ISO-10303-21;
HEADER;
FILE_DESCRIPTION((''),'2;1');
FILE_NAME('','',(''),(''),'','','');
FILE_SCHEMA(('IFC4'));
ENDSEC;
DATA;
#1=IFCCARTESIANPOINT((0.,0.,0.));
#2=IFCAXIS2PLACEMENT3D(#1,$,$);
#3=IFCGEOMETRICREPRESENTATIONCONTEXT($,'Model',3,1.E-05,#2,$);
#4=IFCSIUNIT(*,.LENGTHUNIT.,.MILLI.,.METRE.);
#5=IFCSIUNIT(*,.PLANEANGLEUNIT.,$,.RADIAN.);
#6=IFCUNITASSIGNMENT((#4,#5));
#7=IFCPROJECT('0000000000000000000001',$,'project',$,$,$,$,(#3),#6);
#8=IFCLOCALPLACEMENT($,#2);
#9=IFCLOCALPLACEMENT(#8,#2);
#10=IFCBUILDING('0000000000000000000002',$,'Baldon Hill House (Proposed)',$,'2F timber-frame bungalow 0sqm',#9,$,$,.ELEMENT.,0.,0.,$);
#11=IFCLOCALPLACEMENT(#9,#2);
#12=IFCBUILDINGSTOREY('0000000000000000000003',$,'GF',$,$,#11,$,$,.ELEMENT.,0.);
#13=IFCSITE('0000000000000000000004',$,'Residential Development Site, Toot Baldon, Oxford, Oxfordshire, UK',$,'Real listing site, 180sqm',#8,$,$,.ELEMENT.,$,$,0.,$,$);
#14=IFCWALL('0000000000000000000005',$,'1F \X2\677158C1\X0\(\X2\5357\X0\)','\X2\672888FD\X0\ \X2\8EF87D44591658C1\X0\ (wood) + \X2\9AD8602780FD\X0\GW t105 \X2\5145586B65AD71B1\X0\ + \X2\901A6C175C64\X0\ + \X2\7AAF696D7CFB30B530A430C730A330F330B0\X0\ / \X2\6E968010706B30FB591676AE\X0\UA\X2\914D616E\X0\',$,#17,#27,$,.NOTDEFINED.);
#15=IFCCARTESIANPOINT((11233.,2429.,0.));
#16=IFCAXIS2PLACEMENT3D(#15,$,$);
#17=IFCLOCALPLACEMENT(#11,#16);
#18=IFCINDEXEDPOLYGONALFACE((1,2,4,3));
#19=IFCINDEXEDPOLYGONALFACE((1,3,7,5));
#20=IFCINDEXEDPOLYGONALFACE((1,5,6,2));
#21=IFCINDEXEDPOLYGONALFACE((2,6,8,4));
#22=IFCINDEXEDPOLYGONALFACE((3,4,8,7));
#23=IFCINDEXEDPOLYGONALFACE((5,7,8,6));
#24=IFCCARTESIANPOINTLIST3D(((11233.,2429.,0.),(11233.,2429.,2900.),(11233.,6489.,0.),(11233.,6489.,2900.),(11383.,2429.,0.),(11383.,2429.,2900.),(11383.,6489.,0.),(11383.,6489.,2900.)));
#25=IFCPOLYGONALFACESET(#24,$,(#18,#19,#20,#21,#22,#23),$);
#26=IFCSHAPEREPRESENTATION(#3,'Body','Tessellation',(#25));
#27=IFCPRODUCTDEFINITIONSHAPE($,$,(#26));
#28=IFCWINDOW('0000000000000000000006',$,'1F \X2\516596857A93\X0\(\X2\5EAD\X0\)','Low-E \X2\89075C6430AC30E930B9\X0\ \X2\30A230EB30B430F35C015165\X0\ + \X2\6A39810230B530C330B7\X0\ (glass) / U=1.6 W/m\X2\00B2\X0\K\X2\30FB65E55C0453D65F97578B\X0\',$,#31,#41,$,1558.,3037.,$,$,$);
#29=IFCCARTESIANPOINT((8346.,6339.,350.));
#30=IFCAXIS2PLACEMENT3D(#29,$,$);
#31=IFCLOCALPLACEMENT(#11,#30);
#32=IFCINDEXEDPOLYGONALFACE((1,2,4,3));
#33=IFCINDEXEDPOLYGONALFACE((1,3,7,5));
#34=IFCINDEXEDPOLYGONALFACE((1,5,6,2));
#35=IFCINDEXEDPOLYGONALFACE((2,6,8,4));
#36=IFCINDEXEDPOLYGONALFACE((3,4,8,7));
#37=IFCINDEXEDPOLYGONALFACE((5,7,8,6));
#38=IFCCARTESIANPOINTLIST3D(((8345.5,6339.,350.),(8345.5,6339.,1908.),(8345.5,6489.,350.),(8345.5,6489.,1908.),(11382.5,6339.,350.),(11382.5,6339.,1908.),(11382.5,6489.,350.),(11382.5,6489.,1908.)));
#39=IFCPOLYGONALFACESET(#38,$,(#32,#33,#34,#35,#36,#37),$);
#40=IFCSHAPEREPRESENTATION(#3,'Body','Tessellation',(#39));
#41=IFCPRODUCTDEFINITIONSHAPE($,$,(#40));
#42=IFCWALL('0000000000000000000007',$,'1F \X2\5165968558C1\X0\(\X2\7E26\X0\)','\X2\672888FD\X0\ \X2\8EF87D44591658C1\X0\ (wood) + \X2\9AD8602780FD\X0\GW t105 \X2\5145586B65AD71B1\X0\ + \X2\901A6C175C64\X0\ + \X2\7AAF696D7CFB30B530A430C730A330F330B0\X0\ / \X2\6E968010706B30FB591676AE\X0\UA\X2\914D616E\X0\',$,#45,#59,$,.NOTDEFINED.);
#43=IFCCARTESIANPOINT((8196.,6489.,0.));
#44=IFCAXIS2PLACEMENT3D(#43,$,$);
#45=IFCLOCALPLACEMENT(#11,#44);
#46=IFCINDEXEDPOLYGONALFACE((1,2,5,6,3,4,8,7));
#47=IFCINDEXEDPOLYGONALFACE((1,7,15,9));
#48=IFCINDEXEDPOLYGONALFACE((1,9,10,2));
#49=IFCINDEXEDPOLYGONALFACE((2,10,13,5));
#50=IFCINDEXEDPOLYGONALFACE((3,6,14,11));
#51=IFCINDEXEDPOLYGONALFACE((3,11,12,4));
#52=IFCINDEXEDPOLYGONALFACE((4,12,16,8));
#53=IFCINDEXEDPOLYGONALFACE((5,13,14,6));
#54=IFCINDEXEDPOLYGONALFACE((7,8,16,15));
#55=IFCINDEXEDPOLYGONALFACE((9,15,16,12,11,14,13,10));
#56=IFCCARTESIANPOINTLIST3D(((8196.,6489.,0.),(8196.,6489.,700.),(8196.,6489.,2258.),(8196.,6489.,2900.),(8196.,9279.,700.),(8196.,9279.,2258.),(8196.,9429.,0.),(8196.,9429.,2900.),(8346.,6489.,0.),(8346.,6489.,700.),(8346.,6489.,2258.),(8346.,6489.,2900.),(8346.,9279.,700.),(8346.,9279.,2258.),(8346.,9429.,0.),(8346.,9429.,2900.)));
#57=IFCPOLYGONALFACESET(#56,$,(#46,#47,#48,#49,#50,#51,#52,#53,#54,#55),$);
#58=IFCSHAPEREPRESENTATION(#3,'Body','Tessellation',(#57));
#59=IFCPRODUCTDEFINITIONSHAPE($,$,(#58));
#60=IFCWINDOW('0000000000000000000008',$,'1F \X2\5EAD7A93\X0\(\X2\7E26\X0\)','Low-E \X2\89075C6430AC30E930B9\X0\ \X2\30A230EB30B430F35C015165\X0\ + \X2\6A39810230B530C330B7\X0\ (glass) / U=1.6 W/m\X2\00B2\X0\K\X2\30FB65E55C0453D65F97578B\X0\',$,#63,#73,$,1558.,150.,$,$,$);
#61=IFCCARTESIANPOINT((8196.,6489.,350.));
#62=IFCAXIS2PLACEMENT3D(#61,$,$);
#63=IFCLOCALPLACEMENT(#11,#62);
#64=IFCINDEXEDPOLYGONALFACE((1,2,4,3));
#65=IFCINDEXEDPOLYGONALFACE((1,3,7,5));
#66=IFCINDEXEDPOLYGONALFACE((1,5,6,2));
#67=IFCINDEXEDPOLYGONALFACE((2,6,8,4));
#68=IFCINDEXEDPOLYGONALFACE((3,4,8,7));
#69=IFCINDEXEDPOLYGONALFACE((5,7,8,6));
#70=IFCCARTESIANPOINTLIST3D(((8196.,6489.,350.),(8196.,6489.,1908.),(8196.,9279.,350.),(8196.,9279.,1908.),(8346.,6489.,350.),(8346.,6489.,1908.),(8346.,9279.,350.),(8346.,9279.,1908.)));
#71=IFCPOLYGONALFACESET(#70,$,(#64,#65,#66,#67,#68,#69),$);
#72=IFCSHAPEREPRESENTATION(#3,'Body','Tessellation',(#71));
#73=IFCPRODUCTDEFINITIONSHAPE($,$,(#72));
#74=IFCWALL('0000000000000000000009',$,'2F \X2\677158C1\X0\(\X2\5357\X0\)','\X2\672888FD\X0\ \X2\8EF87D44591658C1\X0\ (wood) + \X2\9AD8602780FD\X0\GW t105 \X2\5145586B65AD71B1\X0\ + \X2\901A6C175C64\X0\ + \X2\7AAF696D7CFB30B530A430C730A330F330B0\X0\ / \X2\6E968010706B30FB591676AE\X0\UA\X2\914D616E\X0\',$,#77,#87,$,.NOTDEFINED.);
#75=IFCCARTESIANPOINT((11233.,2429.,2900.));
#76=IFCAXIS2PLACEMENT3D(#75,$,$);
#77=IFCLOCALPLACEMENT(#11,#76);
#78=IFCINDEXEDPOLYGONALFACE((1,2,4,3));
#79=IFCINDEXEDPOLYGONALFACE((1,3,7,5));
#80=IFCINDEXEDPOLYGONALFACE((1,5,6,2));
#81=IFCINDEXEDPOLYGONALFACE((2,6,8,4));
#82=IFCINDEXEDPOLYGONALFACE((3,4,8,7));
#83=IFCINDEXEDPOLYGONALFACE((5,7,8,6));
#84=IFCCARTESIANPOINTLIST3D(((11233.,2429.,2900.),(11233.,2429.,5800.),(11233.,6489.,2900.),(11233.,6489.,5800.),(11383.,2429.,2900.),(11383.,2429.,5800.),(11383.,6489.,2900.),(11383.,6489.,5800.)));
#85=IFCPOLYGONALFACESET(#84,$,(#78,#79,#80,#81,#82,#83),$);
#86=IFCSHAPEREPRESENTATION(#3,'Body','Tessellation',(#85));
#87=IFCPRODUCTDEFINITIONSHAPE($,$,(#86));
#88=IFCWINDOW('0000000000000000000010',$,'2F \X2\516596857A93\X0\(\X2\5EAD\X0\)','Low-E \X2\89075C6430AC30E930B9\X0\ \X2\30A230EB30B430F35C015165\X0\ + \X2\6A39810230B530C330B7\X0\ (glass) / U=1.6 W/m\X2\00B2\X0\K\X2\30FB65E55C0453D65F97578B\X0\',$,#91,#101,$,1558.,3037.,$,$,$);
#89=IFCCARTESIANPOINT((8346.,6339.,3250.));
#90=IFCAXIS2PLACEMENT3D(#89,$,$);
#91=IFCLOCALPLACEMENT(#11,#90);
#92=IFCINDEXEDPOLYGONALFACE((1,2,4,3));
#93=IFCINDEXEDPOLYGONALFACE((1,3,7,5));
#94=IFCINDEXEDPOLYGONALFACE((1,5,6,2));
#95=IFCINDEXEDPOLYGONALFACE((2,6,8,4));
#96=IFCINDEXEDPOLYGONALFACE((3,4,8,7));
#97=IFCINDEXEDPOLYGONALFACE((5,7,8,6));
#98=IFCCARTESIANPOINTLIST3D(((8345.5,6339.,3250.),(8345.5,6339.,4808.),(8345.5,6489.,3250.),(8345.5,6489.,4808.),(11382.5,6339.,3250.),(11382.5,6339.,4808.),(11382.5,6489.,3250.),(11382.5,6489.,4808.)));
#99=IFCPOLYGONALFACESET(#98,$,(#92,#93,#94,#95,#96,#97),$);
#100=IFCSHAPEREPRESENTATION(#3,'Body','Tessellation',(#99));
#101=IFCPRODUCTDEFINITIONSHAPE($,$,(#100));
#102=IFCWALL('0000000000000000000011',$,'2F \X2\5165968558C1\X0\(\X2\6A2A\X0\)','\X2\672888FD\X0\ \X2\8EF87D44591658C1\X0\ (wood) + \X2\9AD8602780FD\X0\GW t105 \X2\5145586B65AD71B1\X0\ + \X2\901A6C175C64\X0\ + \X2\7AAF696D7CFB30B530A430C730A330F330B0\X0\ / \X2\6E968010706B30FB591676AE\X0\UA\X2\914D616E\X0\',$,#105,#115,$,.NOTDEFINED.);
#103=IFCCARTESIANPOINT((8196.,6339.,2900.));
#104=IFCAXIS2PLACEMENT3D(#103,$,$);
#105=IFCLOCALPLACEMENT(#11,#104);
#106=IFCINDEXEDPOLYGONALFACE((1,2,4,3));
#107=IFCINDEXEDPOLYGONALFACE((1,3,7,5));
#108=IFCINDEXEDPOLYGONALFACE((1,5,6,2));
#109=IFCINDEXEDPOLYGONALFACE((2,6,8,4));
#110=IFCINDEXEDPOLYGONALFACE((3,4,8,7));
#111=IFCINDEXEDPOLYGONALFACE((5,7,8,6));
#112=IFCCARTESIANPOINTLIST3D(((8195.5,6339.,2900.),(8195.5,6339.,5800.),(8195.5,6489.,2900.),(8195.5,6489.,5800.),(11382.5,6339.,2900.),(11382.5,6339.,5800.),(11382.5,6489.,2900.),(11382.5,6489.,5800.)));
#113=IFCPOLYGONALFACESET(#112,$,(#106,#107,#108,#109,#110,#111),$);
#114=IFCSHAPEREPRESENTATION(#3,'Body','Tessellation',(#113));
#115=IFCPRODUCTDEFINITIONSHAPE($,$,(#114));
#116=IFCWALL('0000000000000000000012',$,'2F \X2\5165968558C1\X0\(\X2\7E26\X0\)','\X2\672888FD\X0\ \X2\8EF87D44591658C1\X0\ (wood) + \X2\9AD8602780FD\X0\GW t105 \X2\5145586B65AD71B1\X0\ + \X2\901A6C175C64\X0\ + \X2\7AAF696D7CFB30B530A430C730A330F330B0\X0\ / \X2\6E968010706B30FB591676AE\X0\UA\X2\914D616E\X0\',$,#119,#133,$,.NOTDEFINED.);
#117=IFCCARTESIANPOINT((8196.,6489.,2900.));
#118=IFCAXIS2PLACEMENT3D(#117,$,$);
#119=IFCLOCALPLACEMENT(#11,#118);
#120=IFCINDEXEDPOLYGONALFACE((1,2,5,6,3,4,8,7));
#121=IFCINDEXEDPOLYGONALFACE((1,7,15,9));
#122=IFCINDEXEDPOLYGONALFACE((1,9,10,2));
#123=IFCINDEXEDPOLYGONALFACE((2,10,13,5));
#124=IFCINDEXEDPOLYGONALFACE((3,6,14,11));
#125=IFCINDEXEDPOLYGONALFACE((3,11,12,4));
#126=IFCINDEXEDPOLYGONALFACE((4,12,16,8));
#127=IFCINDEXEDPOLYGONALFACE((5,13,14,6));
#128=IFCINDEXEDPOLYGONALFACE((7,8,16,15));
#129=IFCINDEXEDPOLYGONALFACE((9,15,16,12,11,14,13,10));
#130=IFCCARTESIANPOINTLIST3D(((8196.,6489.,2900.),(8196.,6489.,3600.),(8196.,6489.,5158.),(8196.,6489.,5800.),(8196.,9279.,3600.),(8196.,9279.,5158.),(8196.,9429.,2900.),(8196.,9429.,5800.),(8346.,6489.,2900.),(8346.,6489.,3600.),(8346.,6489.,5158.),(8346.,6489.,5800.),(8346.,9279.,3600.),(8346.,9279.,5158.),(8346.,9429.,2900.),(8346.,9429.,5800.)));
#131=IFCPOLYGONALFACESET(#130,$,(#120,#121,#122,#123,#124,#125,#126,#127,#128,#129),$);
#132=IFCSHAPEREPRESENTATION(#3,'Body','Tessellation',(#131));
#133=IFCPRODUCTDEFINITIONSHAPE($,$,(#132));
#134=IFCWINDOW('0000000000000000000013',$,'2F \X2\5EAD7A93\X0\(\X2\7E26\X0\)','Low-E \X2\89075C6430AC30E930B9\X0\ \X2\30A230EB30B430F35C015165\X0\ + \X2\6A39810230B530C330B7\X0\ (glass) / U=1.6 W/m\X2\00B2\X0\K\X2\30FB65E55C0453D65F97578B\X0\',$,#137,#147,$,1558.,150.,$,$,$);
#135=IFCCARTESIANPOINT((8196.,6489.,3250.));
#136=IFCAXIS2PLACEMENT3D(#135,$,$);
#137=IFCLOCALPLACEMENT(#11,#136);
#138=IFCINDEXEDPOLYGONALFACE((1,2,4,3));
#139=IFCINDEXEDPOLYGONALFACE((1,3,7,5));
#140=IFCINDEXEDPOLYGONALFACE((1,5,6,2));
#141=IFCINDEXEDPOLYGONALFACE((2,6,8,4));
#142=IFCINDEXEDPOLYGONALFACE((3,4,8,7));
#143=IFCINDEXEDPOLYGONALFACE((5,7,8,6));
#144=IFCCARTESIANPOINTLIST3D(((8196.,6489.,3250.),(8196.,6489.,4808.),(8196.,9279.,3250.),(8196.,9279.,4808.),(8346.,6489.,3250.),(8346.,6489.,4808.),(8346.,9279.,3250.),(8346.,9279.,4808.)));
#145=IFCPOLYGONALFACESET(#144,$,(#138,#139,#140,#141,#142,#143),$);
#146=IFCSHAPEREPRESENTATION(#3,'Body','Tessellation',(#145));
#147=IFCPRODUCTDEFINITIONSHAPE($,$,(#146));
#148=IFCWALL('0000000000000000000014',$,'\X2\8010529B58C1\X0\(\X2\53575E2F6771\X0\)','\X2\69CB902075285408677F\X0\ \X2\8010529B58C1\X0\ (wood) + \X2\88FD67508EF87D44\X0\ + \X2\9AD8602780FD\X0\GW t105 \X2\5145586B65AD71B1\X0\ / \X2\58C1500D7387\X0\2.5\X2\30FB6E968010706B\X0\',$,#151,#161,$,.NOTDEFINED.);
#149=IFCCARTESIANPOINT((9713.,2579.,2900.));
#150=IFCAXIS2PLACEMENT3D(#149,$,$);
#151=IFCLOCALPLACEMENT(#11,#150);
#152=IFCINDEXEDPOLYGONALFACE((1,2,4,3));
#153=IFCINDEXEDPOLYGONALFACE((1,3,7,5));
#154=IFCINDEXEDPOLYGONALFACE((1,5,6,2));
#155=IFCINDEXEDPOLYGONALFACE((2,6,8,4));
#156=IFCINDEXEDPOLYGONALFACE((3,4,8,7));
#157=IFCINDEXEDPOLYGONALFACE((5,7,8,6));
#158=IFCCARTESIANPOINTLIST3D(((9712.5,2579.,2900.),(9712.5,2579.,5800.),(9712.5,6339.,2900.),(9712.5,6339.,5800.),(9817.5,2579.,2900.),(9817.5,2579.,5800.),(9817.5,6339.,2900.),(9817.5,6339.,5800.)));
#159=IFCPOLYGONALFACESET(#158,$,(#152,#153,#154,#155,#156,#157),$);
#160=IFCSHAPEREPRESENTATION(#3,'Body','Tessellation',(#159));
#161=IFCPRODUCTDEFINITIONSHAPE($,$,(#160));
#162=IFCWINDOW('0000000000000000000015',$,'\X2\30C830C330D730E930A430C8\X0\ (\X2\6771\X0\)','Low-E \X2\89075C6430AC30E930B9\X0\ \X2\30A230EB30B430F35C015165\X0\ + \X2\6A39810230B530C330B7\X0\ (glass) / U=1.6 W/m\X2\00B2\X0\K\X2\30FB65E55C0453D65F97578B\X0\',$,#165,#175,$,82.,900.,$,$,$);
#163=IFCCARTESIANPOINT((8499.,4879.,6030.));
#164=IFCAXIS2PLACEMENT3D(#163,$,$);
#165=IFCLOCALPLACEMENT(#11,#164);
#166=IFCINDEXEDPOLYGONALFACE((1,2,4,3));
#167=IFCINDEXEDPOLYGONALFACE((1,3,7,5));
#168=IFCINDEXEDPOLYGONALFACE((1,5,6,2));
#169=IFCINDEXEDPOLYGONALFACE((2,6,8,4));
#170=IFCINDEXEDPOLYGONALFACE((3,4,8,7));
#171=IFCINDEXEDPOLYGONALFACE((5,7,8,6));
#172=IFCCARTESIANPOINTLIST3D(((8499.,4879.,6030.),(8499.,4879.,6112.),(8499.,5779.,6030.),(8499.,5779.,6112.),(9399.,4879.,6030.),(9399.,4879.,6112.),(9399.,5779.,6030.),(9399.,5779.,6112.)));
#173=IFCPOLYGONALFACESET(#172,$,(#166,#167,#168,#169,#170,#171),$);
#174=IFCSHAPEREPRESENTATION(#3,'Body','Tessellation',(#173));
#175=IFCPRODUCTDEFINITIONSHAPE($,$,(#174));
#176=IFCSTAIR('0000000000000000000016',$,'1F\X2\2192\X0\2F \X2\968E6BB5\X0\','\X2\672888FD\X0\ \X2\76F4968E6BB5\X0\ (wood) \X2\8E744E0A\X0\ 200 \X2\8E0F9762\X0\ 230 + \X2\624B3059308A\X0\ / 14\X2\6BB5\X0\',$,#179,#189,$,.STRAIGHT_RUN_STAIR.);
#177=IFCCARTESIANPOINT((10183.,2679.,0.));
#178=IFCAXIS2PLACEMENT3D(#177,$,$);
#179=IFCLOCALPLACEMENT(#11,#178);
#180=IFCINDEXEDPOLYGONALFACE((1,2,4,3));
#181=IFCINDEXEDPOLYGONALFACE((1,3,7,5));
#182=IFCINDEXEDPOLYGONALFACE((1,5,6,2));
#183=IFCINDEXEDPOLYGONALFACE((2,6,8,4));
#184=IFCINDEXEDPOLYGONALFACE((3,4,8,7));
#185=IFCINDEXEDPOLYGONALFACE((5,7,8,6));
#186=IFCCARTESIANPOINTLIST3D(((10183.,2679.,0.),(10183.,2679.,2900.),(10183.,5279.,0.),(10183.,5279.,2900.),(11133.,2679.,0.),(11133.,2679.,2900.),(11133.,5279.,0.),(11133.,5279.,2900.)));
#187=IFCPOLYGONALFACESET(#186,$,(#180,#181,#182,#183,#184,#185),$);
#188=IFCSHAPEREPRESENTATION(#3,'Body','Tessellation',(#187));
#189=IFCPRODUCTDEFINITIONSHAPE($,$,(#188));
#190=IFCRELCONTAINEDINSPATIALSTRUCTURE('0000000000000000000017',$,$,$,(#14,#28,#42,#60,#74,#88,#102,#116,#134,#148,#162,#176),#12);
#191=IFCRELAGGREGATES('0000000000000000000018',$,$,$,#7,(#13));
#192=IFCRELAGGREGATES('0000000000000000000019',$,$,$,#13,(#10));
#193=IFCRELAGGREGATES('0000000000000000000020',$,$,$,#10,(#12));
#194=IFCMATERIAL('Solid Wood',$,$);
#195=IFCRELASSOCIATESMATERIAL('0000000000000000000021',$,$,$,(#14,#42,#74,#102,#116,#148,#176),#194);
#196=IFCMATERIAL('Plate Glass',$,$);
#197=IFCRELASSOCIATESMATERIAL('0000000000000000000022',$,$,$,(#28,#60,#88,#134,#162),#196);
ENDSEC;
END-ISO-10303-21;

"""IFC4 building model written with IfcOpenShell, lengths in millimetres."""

from ifc_helpers import new_model, si_unit, frame, frame_2d, origin, place, context, project, spatial, rectangle, extrude, material, element, fill, save


model = new_model("IFC4")

# Units and contexts
model_context = context("Model", 3, precision=1e-05, world=origin())
ifc_project = project(units=[si_unit("LENGTHUNIT", "METRE", prefix="MILLI"), si_unit("PLANEANGLEUNIT", "RADIAN")], contexts=[model_context])

# Site, building, storey
site_placement = place(None, origin())
site = spatial("IfcSite", under=ifc_project, at=site_placement, Name="Residential Development Site, Toot Baldon, Oxford, Oxfordshire, UK", ObjectType="Real listing site, 180sqm", CompositionType="ELEMENT", RefElevation=0.0)
building_placement = place(site_placement, origin())
building = spatial("IfcBuilding", under=site, at=building_placement, Name="Baldon Hill House (Proposed)", ObjectType="2F timber-frame bungalow 0sqm", CompositionType="ELEMENT", ElevationOfRefHeight=0.0, ElevationOfTerrain=0.0)
storey_placement = place(building_placement, origin())
storey = spatial("IfcBuildingStorey", under=building, at=storey_placement, Name="GF", CompositionType="ELEMENT", Elevation=0.0)

# Shared definitions
ifc_material_1 = material(Name="Solid Wood")

# Wall, opening, window
wall_1_placement = place(storey_placement, frame((11233.0, 2429.0, 0.0)))
wall_1 = element("IfcWall", 1, at=wall_1_placement, inside=storey, material=ifc_material_1, Name="1F 東壁(南)", Description="木製 軸組外壁 (wood) + 高性能GW t105 充填断熱 + 通気層 + 窯業系サイディング / 準耐火・外皮UA配慮", PredefinedType="NOTDEFINED", context=model_context, shape_type="SweptSolid", body=[
    extrude(rectangle(XDim=150.0, YDim=4060.0, at=frame_2d((75.0, 2030.0))), frame((11233.0, 2429.0, 0.0)), (0.0, 0.0, 1.0), 2900.0),
])
opening_1_placement = place(storey_placement, frame((8346.0, 6339.0, 350.0)))
opening_1 = element("IfcOpeningElement", 2, at=opening_1_placement, cuts=wall_1, PredefinedType="NOTDEFINED", context=model_context, shape_type="SweptSolid", body=[
    extrude(rectangle(XDim=3037.0, YDim=150.0, at=frame_2d((1518.0, 75.0))), frame((8346.0, 6339.0, 350.0)), (0.0, 0.0, 1.0), 1558.0),
])
ifc_material_2 = material(Name="Plate Glass")
window_1_placement = place(storey_placement, frame((8346.0, 6339.0, 350.0)))
window_1 = element("IfcWindow", 3, at=window_1_placement, inside=storey, material=ifc_material_2, Name="1F 入隅窓(庭)", Description="Low-E 複層ガラス アルゴン封入 + 樹脂サッシ (glass) / U=1.6 W/m²K・日射取得型", OverallHeight=1558.0, OverallWidth=3037.0, context=model_context, shape_type="SweptSolid", body=[
    extrude(rectangle(XDim=3037.0, YDim=150.0, at=frame_2d((1518.0, 75.0))), frame((8346.0, 6339.0, 350.0)), (0.0, 0.0, 1.0), 1558.0),
])
fill(opening_1, window_1)

# Wall, opening, window
wall_2_placement = place(storey_placement, frame((8196.0, 6489.0, 0.0)))
wall_2 = element("IfcWall", 4, at=wall_2_placement, inside=storey, material=ifc_material_1, Name="1F 入隅壁(縦)", Description="木製 軸組外壁 (wood) + 高性能GW t105 充填断熱 + 通気層 + 窯業系サイディング / 準耐火・外皮UA配慮", PredefinedType="NOTDEFINED", context=model_context, shape_type="SweptSolid", body=[
    extrude(rectangle(XDim=150.0, YDim=2940.0, at=frame_2d((75.0, 1470.0))), frame((8196.0, 6489.0, 0.0)), (0.0, 0.0, 1.0), 2900.0),
])
opening_2_placement = place(storey_placement, frame((8196.0, 6489.0, 350.0)))
opening_2 = element("IfcOpeningElement", 5, at=opening_2_placement, cuts=wall_2, PredefinedType="NOTDEFINED", context=model_context, shape_type="SweptSolid", body=[
    extrude(rectangle(XDim=150.0, YDim=2790.0, at=frame_2d((75.0, 1395.0))), frame((8196.0, 6489.0, 350.0)), (0.0, 0.0, 1.0), 1558.0),
])
window_2_placement = place(storey_placement, frame((8196.0, 6489.0, 350.0)))
window_2 = element("IfcWindow", 6, at=window_2_placement, inside=storey, material=ifc_material_2, Name="1F 庭窓(縦)", Description="Low-E 複層ガラス アルゴン封入 + 樹脂サッシ (glass) / U=1.6 W/m²K・日射取得型", OverallHeight=1558.0, OverallWidth=150.0, context=model_context, shape_type="SweptSolid", body=[
    extrude(rectangle(XDim=150.0, YDim=2790.0, at=frame_2d((75.0, 1395.0))), frame((8196.0, 6489.0, 350.0)), (0.0, 0.0, 1.0), 1558.0),
])
fill(opening_2, window_2)

# Wall, opening, window
wall_3_placement = place(storey_placement, frame((11233.0, 2429.0, 2900.0)))
wall_3 = element("IfcWall", 7, at=wall_3_placement, inside=storey, material=ifc_material_1, Name="2F 東壁(南)", Description="木製 軸組外壁 (wood) + 高性能GW t105 充填断熱 + 通気層 + 窯業系サイディング / 準耐火・外皮UA配慮", PredefinedType="NOTDEFINED", context=model_context, shape_type="SweptSolid", body=[
    extrude(rectangle(XDim=150.0, YDim=4060.0, at=frame_2d((75.0, 2030.0))), frame((11233.0, 2429.0, 2900.0)), (0.0, 0.0, 1.0), 2900.0),
])
opening_3_placement = place(storey_placement, frame((8346.0, 6339.0, 3250.0)))
opening_3 = element("IfcOpeningElement", 8, at=opening_3_placement, cuts=wall_3, PredefinedType="NOTDEFINED", context=model_context, shape_type="SweptSolid", body=[
    extrude(rectangle(XDim=3037.0, YDim=150.0, at=frame_2d((1518.0, 75.0))), frame((8346.0, 6339.0, 3250.0)), (0.0, 0.0, 1.0), 1558.0),
])
window_3_placement = place(storey_placement, frame((8346.0, 6339.0, 3250.0)))
window_3 = element("IfcWindow", 9, at=window_3_placement, inside=storey, material=ifc_material_2, Name="2F 入隅窓(庭)", Description="Low-E 複層ガラス アルゴン封入 + 樹脂サッシ (glass) / U=1.6 W/m²K・日射取得型", OverallHeight=1558.0, OverallWidth=3037.0, context=model_context, shape_type="SweptSolid", body=[
    extrude(rectangle(XDim=3037.0, YDim=150.0, at=frame_2d((1518.0, 75.0))), frame((8346.0, 6339.0, 3250.0)), (0.0, 0.0, 1.0), 1558.0),
])
fill(opening_3, window_3)

# Wall
wall_4_placement = place(storey_placement, frame((8196.0, 6339.0, 2900.0)))
element("IfcWall", 10, at=wall_4_placement, inside=storey, material=ifc_material_1, Name="2F 入隅壁(横)", Description="木製 軸組外壁 (wood) + 高性能GW t105 充填断熱 + 通気層 + 窯業系サイディング / 準耐火・外皮UA配慮", PredefinedType="NOTDEFINED", context=model_context, shape_type="SweptSolid", body=[
    extrude(rectangle(XDim=3187.0, YDim=150.0, at=frame_2d((1593.0, 75.0))), frame((8196.0, 6339.0, 2900.0)), (0.0, 0.0, 1.0), 2900.0),
])

# Wall, opening, window
wall_5_placement = place(storey_placement, frame((8196.0, 6489.0, 2900.0)))
wall_5 = element("IfcWall", 11, at=wall_5_placement, inside=storey, material=ifc_material_1, Name="2F 入隅壁(縦)", Description="木製 軸組外壁 (wood) + 高性能GW t105 充填断熱 + 通気層 + 窯業系サイディング / 準耐火・外皮UA配慮", PredefinedType="NOTDEFINED", context=model_context, shape_type="SweptSolid", body=[
    extrude(rectangle(XDim=150.0, YDim=2940.0, at=frame_2d((75.0, 1470.0))), frame((8196.0, 6489.0, 2900.0)), (0.0, 0.0, 1.0), 2900.0),
])
opening_4_placement = place(storey_placement, frame((8196.0, 6489.0, 3250.0)))
opening_4 = element("IfcOpeningElement", 12, at=opening_4_placement, cuts=wall_5, PredefinedType="NOTDEFINED", context=model_context, shape_type="SweptSolid", body=[
    extrude(rectangle(XDim=150.0, YDim=2790.0, at=frame_2d((75.0, 1395.0))), frame((8196.0, 6489.0, 3250.0)), (0.0, 0.0, 1.0), 1558.0),
])
window_4_placement = place(storey_placement, frame((8196.0, 6489.0, 3250.0)))
window_4 = element("IfcWindow", 13, at=window_4_placement, inside=storey, material=ifc_material_2, Name="2F 庭窓(縦)", Description="Low-E 複層ガラス アルゴン封入 + 樹脂サッシ (glass) / U=1.6 W/m²K・日射取得型", OverallHeight=1558.0, OverallWidth=150.0, context=model_context, shape_type="SweptSolid", body=[
    extrude(rectangle(XDim=150.0, YDim=2790.0, at=frame_2d((75.0, 1395.0))), frame((8196.0, 6489.0, 3250.0)), (0.0, 0.0, 1.0), 1558.0),
])
fill(opening_4, window_4)

# Wall
wall_6_placement = place(storey_placement, frame((9713.0, 2579.0, 2900.0)))
element("IfcWall", 14, at=wall_6_placement, inside=storey, material=ifc_material_1, Name="耐力壁(南帯東)", Description="構造用合板 耐力壁 (wood) + 製材軸組 + 高性能GW t105 充填断熱 / 壁倍率2.5・準耐火", PredefinedType="NOTDEFINED", context=model_context, shape_type="SweptSolid", body=[
    extrude(rectangle(XDim=105.0, YDim=3760.0, at=frame_2d((52.0, 1880.0))), frame((9713.0, 2579.0, 2900.0)), (0.0, 0.0, 1.0), 2900.0),
])

# Window
window_5_placement = place(storey_placement, frame((8499.0, 4879.0, 6030.0)))
element("IfcWindow", 15, at=window_5_placement, inside=storey, material=ifc_material_2, Name="トップライト (東)", Description="Low-E 複層ガラス アルゴン封入 + 樹脂サッシ (glass) / U=1.6 W/m²K・日射取得型", OverallHeight=82.0, OverallWidth=900.0, context=model_context, shape_type="SweptSolid", body=[
    extrude(rectangle(XDim=900.0, YDim=900.0, at=frame_2d((450.0, 450.0))), frame((8499.0, 4879.0, 6030.0)), (0.0, 0.0, 1.0), 82.0),
])

# Stair
stair_placement = place(storey_placement, frame((10183.0, 2679.0, 0.0)))
element("IfcStair", 16, at=stair_placement, inside=storey, material=ifc_material_1, Name="1F→2F 階段", Description="木製 直階段 (wood) 蹴上 200 踏面 230 + 手すり / 14段", PredefinedType="STRAIGHT_RUN_STAIR", context=model_context, shape_type="SweptSolid", body=[
    extrude(rectangle(XDim=950.0, YDim=2600.0, at=frame_2d((475.0, 1300.0))), frame((10183.0, 2679.0, 0.0)), (0.0, 0.0, 1.0), 2900.0),
])

save(model, "model.ifc")
